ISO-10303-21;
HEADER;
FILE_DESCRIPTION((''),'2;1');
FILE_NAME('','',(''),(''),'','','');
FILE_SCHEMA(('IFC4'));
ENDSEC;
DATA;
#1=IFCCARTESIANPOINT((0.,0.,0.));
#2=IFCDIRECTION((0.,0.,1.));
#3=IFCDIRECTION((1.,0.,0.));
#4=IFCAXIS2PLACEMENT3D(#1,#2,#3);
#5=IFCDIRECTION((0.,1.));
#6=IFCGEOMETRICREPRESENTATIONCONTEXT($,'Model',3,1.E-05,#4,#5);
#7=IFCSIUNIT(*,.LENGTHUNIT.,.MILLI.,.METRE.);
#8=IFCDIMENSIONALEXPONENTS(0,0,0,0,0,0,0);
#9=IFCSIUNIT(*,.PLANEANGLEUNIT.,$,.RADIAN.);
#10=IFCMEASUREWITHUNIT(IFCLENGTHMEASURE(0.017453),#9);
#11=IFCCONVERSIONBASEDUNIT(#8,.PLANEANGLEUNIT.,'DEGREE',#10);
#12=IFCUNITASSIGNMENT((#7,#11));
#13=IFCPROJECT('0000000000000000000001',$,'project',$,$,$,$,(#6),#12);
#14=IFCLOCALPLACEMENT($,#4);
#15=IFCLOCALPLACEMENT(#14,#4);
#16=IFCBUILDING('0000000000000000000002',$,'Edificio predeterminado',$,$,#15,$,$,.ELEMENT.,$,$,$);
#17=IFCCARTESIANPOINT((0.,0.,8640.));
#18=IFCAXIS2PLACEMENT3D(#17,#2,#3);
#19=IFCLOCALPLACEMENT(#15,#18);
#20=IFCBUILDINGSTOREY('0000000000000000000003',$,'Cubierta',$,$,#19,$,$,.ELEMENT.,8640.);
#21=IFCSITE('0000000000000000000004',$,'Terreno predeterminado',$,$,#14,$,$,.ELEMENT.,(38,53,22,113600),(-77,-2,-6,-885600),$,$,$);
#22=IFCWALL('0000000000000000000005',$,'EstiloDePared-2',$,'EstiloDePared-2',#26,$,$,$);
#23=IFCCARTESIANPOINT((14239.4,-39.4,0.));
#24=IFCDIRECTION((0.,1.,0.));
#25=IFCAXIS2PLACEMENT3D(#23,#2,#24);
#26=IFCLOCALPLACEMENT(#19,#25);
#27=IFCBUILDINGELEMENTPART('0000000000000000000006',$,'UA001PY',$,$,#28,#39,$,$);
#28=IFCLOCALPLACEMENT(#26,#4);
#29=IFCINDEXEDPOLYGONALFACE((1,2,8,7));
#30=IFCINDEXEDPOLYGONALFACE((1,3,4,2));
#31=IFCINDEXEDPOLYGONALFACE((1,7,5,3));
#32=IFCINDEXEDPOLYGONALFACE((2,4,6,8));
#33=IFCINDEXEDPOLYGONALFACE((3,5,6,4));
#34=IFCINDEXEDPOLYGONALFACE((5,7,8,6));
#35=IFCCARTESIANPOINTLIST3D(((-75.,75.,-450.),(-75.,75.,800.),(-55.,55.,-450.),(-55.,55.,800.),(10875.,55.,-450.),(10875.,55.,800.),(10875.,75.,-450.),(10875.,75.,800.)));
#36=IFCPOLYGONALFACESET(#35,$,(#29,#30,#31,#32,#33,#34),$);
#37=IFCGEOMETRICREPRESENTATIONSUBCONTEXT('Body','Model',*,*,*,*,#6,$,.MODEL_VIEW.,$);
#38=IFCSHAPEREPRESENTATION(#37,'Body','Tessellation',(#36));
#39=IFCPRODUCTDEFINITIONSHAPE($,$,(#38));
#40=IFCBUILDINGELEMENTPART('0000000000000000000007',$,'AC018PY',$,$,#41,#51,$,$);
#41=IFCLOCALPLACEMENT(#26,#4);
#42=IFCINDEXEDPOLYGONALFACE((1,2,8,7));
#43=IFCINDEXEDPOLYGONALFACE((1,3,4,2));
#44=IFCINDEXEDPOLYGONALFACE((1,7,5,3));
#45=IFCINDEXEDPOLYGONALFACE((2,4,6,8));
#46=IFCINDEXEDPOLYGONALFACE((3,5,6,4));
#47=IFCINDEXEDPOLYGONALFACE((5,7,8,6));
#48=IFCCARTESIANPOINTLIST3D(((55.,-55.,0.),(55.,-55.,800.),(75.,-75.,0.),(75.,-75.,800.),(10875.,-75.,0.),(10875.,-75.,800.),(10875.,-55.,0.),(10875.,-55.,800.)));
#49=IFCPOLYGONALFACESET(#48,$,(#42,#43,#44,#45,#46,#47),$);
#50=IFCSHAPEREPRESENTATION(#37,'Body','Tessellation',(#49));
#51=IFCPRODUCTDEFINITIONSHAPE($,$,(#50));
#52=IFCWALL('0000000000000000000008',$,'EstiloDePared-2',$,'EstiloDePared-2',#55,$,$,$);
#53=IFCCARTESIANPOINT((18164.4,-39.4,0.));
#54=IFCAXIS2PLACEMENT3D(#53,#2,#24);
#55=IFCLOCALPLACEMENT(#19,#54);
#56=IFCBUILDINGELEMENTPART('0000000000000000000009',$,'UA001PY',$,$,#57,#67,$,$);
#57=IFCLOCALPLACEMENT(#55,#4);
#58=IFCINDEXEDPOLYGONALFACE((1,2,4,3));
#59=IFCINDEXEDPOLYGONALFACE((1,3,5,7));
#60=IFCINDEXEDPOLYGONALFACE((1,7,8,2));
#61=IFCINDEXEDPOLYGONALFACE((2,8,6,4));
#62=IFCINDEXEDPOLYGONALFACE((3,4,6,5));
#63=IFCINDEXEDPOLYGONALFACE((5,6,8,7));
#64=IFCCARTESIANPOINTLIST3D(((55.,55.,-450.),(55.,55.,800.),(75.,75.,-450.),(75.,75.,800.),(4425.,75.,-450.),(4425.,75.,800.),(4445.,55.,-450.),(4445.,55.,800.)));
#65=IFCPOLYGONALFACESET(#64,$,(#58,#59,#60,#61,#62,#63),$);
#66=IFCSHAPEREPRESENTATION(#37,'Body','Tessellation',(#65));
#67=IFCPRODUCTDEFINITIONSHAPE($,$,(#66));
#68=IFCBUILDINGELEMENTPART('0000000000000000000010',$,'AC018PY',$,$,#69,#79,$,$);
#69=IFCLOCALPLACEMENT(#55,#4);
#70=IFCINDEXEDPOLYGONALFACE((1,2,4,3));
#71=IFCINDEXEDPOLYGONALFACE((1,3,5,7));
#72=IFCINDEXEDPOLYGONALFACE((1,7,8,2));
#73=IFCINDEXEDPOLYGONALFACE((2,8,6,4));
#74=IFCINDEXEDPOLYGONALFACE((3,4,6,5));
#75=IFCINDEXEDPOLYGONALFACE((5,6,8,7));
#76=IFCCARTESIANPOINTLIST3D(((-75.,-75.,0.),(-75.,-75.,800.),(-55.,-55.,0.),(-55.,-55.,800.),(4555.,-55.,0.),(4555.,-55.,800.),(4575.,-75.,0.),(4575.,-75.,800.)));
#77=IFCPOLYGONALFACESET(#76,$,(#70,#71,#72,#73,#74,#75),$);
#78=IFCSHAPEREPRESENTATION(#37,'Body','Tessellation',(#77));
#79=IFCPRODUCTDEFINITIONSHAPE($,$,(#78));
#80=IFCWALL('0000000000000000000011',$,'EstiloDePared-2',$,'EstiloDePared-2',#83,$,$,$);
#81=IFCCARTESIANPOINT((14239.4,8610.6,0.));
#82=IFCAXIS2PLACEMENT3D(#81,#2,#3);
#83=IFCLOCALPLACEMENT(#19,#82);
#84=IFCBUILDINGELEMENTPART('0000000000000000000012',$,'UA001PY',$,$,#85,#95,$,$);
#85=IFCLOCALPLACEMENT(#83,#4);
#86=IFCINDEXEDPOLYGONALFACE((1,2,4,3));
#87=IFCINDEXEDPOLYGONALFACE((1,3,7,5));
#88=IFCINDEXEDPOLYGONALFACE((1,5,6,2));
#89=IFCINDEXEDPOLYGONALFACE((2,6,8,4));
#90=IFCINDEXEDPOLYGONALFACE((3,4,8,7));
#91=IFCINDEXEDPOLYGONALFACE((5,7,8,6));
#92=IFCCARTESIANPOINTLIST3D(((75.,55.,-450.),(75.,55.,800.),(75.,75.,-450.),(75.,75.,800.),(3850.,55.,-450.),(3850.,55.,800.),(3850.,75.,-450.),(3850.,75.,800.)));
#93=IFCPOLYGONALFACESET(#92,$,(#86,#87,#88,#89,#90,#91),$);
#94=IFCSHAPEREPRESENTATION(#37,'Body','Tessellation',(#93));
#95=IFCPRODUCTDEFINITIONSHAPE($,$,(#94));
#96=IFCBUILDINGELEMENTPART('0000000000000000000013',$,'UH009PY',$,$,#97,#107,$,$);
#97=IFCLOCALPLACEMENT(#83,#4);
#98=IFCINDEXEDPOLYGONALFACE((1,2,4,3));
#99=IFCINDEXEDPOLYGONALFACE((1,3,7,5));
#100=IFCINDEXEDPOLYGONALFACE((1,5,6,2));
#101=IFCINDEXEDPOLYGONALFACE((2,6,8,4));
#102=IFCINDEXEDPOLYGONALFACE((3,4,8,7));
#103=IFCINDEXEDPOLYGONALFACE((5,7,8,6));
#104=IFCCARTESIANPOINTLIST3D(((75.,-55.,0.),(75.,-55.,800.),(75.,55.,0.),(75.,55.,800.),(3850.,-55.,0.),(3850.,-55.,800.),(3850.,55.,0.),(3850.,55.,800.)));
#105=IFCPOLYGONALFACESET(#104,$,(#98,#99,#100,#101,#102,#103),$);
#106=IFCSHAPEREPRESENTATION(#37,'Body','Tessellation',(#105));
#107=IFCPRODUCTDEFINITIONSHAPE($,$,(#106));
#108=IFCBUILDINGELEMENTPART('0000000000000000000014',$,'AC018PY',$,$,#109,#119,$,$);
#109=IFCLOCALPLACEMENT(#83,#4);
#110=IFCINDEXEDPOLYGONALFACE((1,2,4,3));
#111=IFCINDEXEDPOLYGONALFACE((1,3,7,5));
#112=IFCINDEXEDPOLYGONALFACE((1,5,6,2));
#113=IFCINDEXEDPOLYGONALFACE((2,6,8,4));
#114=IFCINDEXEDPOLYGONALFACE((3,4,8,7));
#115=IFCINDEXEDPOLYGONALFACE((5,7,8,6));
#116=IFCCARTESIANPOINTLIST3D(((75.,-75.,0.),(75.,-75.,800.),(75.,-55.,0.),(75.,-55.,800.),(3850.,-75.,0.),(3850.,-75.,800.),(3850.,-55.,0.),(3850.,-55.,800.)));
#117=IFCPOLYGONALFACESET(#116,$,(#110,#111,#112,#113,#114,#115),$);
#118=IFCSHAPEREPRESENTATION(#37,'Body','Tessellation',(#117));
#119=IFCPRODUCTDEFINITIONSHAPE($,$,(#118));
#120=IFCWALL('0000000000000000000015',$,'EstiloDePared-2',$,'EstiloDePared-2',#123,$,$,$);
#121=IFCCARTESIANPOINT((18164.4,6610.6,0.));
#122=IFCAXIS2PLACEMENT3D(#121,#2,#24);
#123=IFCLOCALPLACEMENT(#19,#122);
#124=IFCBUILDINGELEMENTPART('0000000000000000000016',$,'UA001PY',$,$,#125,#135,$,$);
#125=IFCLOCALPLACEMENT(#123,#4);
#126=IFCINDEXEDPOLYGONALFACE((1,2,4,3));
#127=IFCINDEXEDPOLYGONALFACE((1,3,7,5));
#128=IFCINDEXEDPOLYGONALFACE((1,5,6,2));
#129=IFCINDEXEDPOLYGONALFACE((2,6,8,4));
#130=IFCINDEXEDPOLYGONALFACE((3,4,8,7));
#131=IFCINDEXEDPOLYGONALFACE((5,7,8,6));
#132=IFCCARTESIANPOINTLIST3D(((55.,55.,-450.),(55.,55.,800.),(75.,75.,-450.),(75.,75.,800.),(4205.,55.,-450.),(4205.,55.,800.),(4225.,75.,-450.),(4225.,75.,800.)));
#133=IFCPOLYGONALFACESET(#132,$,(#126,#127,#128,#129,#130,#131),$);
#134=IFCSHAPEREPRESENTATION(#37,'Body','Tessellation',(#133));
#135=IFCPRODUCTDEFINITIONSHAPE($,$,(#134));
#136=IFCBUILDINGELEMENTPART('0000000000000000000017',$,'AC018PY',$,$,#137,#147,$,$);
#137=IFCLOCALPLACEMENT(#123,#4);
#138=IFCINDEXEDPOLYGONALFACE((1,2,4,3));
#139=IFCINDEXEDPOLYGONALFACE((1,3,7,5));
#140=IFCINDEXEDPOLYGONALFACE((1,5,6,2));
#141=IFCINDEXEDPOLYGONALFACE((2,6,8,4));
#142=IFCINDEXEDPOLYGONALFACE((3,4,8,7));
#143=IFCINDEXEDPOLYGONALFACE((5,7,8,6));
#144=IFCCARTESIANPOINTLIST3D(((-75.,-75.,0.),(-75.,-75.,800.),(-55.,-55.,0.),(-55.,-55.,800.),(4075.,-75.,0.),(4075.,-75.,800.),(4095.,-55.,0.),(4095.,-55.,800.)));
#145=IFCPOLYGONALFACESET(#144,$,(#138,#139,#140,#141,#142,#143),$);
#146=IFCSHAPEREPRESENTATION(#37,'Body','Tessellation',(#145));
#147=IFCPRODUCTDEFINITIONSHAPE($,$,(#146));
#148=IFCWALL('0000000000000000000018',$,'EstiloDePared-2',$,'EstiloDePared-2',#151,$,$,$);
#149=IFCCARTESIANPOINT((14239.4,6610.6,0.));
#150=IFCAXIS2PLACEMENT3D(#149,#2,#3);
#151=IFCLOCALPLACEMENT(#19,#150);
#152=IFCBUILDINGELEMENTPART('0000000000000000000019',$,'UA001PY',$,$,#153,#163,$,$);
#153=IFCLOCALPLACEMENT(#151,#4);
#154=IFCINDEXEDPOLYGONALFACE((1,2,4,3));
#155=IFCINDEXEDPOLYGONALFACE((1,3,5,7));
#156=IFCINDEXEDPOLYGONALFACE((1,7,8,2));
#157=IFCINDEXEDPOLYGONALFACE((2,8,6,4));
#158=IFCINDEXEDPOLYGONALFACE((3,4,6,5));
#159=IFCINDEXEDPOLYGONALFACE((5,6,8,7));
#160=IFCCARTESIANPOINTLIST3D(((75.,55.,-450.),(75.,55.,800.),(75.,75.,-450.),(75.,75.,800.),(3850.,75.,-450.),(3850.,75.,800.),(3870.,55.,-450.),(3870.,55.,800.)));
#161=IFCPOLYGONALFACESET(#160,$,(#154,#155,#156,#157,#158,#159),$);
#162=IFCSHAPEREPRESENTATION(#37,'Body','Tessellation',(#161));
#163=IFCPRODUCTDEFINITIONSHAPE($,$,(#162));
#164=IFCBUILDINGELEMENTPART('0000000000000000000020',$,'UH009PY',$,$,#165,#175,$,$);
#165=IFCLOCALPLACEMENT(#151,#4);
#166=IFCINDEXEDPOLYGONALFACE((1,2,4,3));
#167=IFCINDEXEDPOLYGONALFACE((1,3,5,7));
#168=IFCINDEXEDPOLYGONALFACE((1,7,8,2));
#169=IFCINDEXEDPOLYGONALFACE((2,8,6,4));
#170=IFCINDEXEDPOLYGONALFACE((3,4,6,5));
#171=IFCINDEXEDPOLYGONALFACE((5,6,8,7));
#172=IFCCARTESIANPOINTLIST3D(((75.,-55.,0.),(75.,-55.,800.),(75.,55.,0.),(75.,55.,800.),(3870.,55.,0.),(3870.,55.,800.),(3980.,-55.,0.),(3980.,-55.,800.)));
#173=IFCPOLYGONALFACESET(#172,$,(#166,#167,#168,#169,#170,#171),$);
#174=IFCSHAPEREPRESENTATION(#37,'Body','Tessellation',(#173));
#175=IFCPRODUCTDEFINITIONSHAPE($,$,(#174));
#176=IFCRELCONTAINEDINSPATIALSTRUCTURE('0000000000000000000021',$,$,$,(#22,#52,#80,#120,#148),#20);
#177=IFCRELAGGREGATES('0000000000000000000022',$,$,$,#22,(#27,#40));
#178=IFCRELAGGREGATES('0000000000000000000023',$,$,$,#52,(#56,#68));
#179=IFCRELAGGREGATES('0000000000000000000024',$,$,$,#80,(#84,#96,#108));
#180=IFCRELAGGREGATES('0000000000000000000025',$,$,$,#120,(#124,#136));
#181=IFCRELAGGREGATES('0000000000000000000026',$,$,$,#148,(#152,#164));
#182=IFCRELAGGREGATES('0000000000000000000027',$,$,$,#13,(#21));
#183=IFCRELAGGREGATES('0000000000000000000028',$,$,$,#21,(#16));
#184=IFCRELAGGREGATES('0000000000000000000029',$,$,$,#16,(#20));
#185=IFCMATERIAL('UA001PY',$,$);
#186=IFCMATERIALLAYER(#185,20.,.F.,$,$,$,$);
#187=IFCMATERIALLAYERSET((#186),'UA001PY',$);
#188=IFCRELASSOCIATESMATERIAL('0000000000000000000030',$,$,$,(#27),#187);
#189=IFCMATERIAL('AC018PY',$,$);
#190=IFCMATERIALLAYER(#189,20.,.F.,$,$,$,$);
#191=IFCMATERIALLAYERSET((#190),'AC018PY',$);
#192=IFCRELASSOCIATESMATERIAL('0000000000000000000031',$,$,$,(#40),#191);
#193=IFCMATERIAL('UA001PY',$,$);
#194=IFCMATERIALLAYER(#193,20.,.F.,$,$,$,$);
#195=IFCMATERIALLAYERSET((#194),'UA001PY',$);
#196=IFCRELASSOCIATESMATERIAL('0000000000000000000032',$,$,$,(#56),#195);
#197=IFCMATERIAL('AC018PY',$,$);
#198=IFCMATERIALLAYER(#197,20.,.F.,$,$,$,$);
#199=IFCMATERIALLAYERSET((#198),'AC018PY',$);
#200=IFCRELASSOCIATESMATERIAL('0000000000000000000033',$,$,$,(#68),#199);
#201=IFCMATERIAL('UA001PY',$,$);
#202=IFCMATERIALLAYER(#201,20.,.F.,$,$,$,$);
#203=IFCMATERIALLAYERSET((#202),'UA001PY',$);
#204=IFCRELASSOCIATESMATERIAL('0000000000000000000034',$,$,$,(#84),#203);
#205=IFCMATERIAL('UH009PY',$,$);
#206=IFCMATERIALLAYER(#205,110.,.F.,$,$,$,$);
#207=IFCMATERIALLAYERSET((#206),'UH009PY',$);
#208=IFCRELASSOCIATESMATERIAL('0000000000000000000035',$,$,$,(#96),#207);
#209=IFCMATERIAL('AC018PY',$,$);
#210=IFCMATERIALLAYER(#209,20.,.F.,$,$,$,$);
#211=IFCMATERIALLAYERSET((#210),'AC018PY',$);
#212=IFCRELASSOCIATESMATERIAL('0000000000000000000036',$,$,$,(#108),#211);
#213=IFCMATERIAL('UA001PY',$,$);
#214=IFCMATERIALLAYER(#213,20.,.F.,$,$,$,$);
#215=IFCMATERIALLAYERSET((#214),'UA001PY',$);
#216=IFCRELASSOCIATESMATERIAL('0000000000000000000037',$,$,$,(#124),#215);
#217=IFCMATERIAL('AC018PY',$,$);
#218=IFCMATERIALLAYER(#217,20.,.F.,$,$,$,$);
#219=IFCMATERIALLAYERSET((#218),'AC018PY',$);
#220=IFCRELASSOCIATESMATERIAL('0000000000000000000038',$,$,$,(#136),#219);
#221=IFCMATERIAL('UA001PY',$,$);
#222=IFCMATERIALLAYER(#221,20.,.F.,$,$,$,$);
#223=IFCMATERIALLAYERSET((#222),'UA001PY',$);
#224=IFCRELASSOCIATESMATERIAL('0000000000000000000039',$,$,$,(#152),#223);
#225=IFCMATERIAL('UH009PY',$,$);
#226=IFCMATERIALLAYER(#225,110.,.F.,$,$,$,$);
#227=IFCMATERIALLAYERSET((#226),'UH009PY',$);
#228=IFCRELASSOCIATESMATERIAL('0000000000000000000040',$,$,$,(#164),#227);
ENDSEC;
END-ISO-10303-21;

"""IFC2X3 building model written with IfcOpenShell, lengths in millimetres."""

from ifc_helpers import new_model, entity, si_unit, converted_unit, direction, frame, origin_with_axes, place, context, subcontext, project, spatial, polyline, outline, extrude, material, layer, layer_set, layer_usage, element, aggregate, save


model = new_model("IFC2X3")

# Units and contexts
model_context = context("Model", 3, precision=1e-05, world=origin_with_axes(), true_north=direction((0.0, 1.0)))
body_context = subcontext(model_context, "Body", "Model", "MODEL_VIEW")
ifc_project = project(units=[si_unit("LENGTHUNIT", "METRE", prefix="MILLI"), converted_unit("PLANEANGLEUNIT", "DEGREE", entity("IfcLengthMeasure", 0.017453), si_unit("PLANEANGLEUNIT", "RADIAN"), dimensions=[0, 0, 0, 0, 0, 0, 0])], contexts=[model_context])

# Site, building, storey
site_placement = place(None, origin_with_axes())
site = spatial("IfcSite", under=ifc_project, at=site_placement, Name="Terreno predeterminado", CompositionType="ELEMENT", RefLatitude=(38, 53, 22, 113600), RefLongitude=(-77, -2, -6, -885600))
building_placement = place(site_placement, origin_with_axes())
building = spatial("IfcBuilding", under=site, at=building_placement, Name="Edificio predeterminado", CompositionType="ELEMENT")
storey_placement = place(building_placement, frame((0.0, 0.0, 8640.0), z_axis=(0.0, 0.0, 1.0), x_axis=(1.0, 0.0, 0.0)))
storey = spatial("IfcBuildingStorey", under=building, at=storey_placement, Name="Cubierta", CompositionType="ELEMENT", Elevation=8640.0)

# Walls, building element parts
wall_1_placement = place(storey_placement, frame((14239.4, -39.4, 0.0), z_axis=(0.0, 0.0, 1.0), x_axis=(0.0, 1.0, 0.0)))
wall_1 = element("IfcWall", 1, at=wall_1_placement, inside=storey, Name="EstiloDePared-2", ObjectType="EstiloDePared-2")
ifc_material_1 = material(Name="UA001PY")
ifc_layer_1 = layer(ifc_material_1, 20.0, ventilated=False)
ifc_layer_set_1 = layer_set([ifc_layer_1], Name="UA001PY")
ifc_layer_usage_1 = layer_usage(ifc_layer_set_1, "AXIS2", "NEGATIVE", -75.0)
building_element_part_1_placement = place(wall_1_placement, origin_with_axes())
building_element_part_1 = element("IfcBuildingElementPart", 2, at=building_element_part_1_placement, material=ifc_layer_usage_1, Name="UA001PY", context=body_context, shape_type="SweptSolid", body=[
    extrude(outline(polyline([(10875.0, 75.0), (10875.0, 55.0), (-55.0, 55.0), (-75.0, 75.0), (10875.0, 75.0)])), frame((0.0, 0.0, -450.0), z_axis=(0.0, 0.0, 1.0), x_axis=(1.0, 0.0, 0.0)), (0.0, 0.0, 1.0), 1250.0),
])
ifc_material_2 = material(Name="AC018PY")
ifc_layer_2 = layer(ifc_material_2, 20.0, ventilated=False)
ifc_layer_set_2 = layer_set([ifc_layer_2], Name="AC018PY")
ifc_layer_usage_2 = layer_usage(ifc_layer_set_2, "AXIS2", "NEGATIVE", 55.0)
building_element_part_2_placement = place(wall_1_placement, origin_with_axes())
building_element_part_2 = element("IfcBuildingElementPart", 3, at=building_element_part_2_placement, material=ifc_layer_usage_2, Name="AC018PY", context=body_context, shape_type="SweptSolid", body=[
    extrude(outline(polyline([(10875.0, -55.0), (10875.0, -75.0), (75.0, -75.0), (55.0, -55.0), (10875.0, -55.0)])), origin_with_axes(), (0.0, 0.0, 1.0), 800.0),
])
aggregate(wall_1, [building_element_part_1, building_element_part_2])
wall_2_placement = place(storey_placement, frame((18164.4, -39.4, 0.0), z_axis=(0.0, 0.0, 1.0), x_axis=(0.0, 1.0, 0.0)))
wall_2 = element("IfcWall", 4, at=wall_2_placement, inside=storey, Name="EstiloDePared-2", ObjectType="EstiloDePared-2")
ifc_material_3 = material(Name="UA001PY")
ifc_layer_3 = layer(ifc_material_3, 20.0, ventilated=False)
ifc_layer_set_3 = layer_set([ifc_layer_3], Name="UA001PY")
ifc_layer_usage_3 = layer_usage(ifc_layer_set_3, "AXIS2", "NEGATIVE", -75.0)
building_element_part_3_placement = place(wall_2_placement, origin_with_axes())
building_element_part_3 = element("IfcBuildingElementPart", 5, at=building_element_part_3_placement, material=ifc_layer_usage_3, Name="UA001PY", context=body_context, shape_type="SweptSolid", body=[
    extrude(outline(polyline([(4425.0, 75.0), (4445.0, 55.0), (55.0, 55.0), (75.0, 75.0), (4425.0, 75.0)])), frame((0.0, 0.0, -450.0), z_axis=(0.0, 0.0, 1.0), x_axis=(1.0, 0.0, 0.0)), (0.0, 0.0, 1.0), 1250.0),
])
ifc_material_4 = material(Name="AC018PY")
ifc_layer_4 = layer(ifc_material_4, 20.0, ventilated=False)
ifc_layer_set_4 = layer_set([ifc_layer_4], Name="AC018PY")
ifc_layer_usage_4 = layer_usage(ifc_layer_set_4, "AXIS2", "NEGATIVE", 55.0)
building_element_part_4_placement = place(wall_2_placement, origin_with_axes())
building_element_part_4 = element("IfcBuildingElementPart", 6, at=building_element_part_4_placement, material=ifc_layer_usage_4, Name="AC018PY", context=body_context, shape_type="SweptSolid", body=[
    extrude(outline(polyline([(4555.0, -55.0), (4575.0, -75.0), (-75.0, -75.0), (-55.0, -55.0), (4555.0, -55.0)])), origin_with_axes(), (0.0, 0.0, 1.0), 800.0),
])
aggregate(wall_2, [building_element_part_3, building_element_part_4])
wall_3_placement = place(storey_placement, frame((14239.4, 8610.6, 0.0), z_axis=(0.0, 0.0, 1.0), x_axis=(1.0, 0.0, 0.0)))
wall_3 = element("IfcWall", 7, at=wall_3_placement, inside=storey, Name="EstiloDePared-2", ObjectType="EstiloDePared-2")
ifc_material_5 = material(Name="UA001PY")
ifc_layer_5 = layer(ifc_material_5, 20.0, ventilated=False)
ifc_layer_set_5 = layer_set([ifc_layer_5], Name="UA001PY")
ifc_layer_usage_5 = layer_usage(ifc_layer_set_5, "AXIS2", "NEGATIVE", -75.0)
building_element_part_5_placement = place(wall_3_placement, origin_with_axes())
building_element_part_5 = element("IfcBuildingElementPart", 8, at=building_element_part_5_placement, material=ifc_layer_usage_5, Name="UA001PY", context=body_context, shape_type="SweptSolid", body=[
    extrude(outline(polyline([(3850.0, 75.0), (3850.0, 55.0), (75.0, 55.0), (75.0, 75.0), (3850.0, 75.0)])), frame((0.0, 0.0, -450.0), z_axis=(0.0, 0.0, 1.0), x_axis=(1.0, 0.0, 0.0)), (0.0, 0.0, 1.0), 1250.0),
])
ifc_material_6 = material(Name="UH009PY")
ifc_layer_6 = layer(ifc_material_6, 110.0, ventilated=False)
ifc_layer_set_6 = layer_set([ifc_layer_6], Name="UH009PY")
ifc_layer_usage_6 = layer_usage(ifc_layer_set_6, "AXIS2", "NEGATIVE", -55.0)
building_element_part_6_placement = place(wall_3_placement, origin_with_axes())
building_element_part_6 = element("IfcBuildingElementPart", 9, at=building_element_part_6_placement, material=ifc_layer_usage_6, Name="UH009PY", context=body_context, shape_type="SweptSolid", body=[
    extrude(outline(polyline([(3850.0, 55.0), (3850.0, -55.0), (75.0, -55.0), (75.0, 55.0), (3850.0, 55.0)])), origin_with_axes(), (0.0, 0.0, 1.0), 800.0),
])
ifc_material_7 = material(Name="AC018PY")
ifc_layer_7 = layer(ifc_material_7, 20.0, ventilated=False)
ifc_layer_set_7 = layer_set([ifc_layer_7], Name="AC018PY")
ifc_layer_usage_7 = layer_usage(ifc_layer_set_7, "AXIS2", "NEGATIVE", 55.0)
building_element_part_7_placement = place(wall_3_placement, origin_with_axes())
building_element_part_7 = element("IfcBuildingElementPart", 10, at=building_element_part_7_placement, material=ifc_layer_usage_7, Name="AC018PY", context=body_context, shape_type="SweptSolid", body=[
    extrude(outline(polyline([(3850.0, -55.0), (3850.0, -75.0), (75.0, -75.0), (75.0, -55.0), (3850.0, -55.0)])), origin_with_axes(), (0.0, 0.0, 1.0), 800.0),
])
aggregate(wall_3, [building_element_part_5, building_element_part_6, building_element_part_7])
wall_4_placement = place(storey_placement, frame((18164.4, 6610.6, 0.0), z_axis=(0.0, 0.0, 1.0), x_axis=(0.0, 1.0, 0.0)))
wall_4 = element("IfcWall", 11, at=wall_4_placement, inside=storey, Name="EstiloDePared-2", ObjectType="EstiloDePared-2")
ifc_material_8 = material(Name="UA001PY")
ifc_layer_8 = layer(ifc_material_8, 20.0, ventilated=False)
ifc_layer_set_8 = layer_set([ifc_layer_8], Name="UA001PY")
ifc_layer_usage_8 = layer_usage(ifc_layer_set_8, "AXIS2", "NEGATIVE", -75.0)
building_element_part_8_placement = place(wall_4_placement, origin_with_axes())
building_element_part_8 = element("IfcBuildingElementPart", 12, at=building_element_part_8_placement, material=ifc_layer_usage_8, Name="UA001PY", context=body_context, shape_type="SweptSolid", body=[
    extrude(outline(polyline([(4225.0, 75.0), (4205.0, 55.0), (55.0, 55.0), (75.0, 75.0), (4225.0, 75.0)])), frame((0.0, 0.0, -450.0), z_axis=(0.0, 0.0, 1.0), x_axis=(1.0, 0.0, 0.0)), (0.0, 0.0, 1.0), 1250.0),
])
ifc_material_9 = material(Name="AC018PY")
ifc_layer_9 = layer(ifc_material_9, 20.0, ventilated=False)
ifc_layer_set_9 = layer_set([ifc_layer_9], Name="AC018PY")
ifc_layer_usage_9 = layer_usage(ifc_layer_set_9, "AXIS2", "NEGATIVE", 55.0)
building_element_part_9_placement = place(wall_4_placement, origin_with_axes())
building_element_part_9 = element("IfcBuildingElementPart", 13, at=building_element_part_9_placement, material=ifc_layer_usage_9, Name="AC018PY", context=body_context, shape_type="SweptSolid", body=[
    extrude(outline(polyline([(4095.0, -55.0), (4075.0, -75.0), (-75.0, -75.0), (-55.0, -55.0), (4095.0, -55.0)])), origin_with_axes(), (0.0, 0.0, 1.0), 800.0),
])
aggregate(wall_4, [building_element_part_8, building_element_part_9])
wall_5_placement = place(storey_placement, frame((14239.4, 6610.6, 0.0), z_axis=(0.0, 0.0, 1.0), x_axis=(1.0, 0.0, 0.0)))
wall_5 = element("IfcWall", 14, at=wall_5_placement, inside=storey, Name="EstiloDePared-2", ObjectType="EstiloDePared-2")
ifc_material_10 = material(Name="UA001PY")
ifc_layer_10 = layer(ifc_material_10, 20.0, ventilated=False)
ifc_layer_set_10 = layer_set([ifc_layer_10], Name="UA001PY")
ifc_layer_usage_10 = layer_usage(ifc_layer_set_10, "AXIS2", "NEGATIVE", -75.0)
building_element_part_10_placement = place(wall_5_placement, origin_with_axes())
building_element_part_10 = element("IfcBuildingElementPart", 15, at=building_element_part_10_placement, material=ifc_layer_usage_10, Name="UA001PY", context=body_context, shape_type="SweptSolid", body=[
    extrude(outline(polyline([(3850.0, 75.0), (3870.0, 55.0), (75.0, 55.0), (75.0, 75.0), (3850.0, 75.0)])), frame((0.0, 0.0, -450.0), z_axis=(0.0, 0.0, 1.0), x_axis=(1.0, 0.0, 0.0)), (0.0, 0.0, 1.0), 1250.0),
])
ifc_material_11 = material(Name="UH009PY")
ifc_layer_11 = layer(ifc_material_11, 110.0, ventilated=False)
ifc_layer_set_11 = layer_set([ifc_layer_11], Name="UH009PY")
ifc_layer_usage_11 = layer_usage(ifc_layer_set_11, "AXIS2", "NEGATIVE", -55.0)
building_element_part_11_placement = place(wall_5_placement, origin_with_axes())
building_element_part_11 = element("IfcBuildingElementPart", 16, at=building_element_part_11_placement, material=ifc_layer_usage_11, Name="UH009PY", context=body_context, shape_type="SweptSolid", body=[
    extrude(outline(polyline([(3870.0, 55.0), (3980.0, -55.0), (75.0, -55.0), (75.0, 55.0), (3870.0, 55.0)])), origin_with_axes(), (0.0, 0.0, 1.0), 800.0),
])
aggregate(wall_5, [building_element_part_10, building_element_part_11])

save(model, "model.ifc")
